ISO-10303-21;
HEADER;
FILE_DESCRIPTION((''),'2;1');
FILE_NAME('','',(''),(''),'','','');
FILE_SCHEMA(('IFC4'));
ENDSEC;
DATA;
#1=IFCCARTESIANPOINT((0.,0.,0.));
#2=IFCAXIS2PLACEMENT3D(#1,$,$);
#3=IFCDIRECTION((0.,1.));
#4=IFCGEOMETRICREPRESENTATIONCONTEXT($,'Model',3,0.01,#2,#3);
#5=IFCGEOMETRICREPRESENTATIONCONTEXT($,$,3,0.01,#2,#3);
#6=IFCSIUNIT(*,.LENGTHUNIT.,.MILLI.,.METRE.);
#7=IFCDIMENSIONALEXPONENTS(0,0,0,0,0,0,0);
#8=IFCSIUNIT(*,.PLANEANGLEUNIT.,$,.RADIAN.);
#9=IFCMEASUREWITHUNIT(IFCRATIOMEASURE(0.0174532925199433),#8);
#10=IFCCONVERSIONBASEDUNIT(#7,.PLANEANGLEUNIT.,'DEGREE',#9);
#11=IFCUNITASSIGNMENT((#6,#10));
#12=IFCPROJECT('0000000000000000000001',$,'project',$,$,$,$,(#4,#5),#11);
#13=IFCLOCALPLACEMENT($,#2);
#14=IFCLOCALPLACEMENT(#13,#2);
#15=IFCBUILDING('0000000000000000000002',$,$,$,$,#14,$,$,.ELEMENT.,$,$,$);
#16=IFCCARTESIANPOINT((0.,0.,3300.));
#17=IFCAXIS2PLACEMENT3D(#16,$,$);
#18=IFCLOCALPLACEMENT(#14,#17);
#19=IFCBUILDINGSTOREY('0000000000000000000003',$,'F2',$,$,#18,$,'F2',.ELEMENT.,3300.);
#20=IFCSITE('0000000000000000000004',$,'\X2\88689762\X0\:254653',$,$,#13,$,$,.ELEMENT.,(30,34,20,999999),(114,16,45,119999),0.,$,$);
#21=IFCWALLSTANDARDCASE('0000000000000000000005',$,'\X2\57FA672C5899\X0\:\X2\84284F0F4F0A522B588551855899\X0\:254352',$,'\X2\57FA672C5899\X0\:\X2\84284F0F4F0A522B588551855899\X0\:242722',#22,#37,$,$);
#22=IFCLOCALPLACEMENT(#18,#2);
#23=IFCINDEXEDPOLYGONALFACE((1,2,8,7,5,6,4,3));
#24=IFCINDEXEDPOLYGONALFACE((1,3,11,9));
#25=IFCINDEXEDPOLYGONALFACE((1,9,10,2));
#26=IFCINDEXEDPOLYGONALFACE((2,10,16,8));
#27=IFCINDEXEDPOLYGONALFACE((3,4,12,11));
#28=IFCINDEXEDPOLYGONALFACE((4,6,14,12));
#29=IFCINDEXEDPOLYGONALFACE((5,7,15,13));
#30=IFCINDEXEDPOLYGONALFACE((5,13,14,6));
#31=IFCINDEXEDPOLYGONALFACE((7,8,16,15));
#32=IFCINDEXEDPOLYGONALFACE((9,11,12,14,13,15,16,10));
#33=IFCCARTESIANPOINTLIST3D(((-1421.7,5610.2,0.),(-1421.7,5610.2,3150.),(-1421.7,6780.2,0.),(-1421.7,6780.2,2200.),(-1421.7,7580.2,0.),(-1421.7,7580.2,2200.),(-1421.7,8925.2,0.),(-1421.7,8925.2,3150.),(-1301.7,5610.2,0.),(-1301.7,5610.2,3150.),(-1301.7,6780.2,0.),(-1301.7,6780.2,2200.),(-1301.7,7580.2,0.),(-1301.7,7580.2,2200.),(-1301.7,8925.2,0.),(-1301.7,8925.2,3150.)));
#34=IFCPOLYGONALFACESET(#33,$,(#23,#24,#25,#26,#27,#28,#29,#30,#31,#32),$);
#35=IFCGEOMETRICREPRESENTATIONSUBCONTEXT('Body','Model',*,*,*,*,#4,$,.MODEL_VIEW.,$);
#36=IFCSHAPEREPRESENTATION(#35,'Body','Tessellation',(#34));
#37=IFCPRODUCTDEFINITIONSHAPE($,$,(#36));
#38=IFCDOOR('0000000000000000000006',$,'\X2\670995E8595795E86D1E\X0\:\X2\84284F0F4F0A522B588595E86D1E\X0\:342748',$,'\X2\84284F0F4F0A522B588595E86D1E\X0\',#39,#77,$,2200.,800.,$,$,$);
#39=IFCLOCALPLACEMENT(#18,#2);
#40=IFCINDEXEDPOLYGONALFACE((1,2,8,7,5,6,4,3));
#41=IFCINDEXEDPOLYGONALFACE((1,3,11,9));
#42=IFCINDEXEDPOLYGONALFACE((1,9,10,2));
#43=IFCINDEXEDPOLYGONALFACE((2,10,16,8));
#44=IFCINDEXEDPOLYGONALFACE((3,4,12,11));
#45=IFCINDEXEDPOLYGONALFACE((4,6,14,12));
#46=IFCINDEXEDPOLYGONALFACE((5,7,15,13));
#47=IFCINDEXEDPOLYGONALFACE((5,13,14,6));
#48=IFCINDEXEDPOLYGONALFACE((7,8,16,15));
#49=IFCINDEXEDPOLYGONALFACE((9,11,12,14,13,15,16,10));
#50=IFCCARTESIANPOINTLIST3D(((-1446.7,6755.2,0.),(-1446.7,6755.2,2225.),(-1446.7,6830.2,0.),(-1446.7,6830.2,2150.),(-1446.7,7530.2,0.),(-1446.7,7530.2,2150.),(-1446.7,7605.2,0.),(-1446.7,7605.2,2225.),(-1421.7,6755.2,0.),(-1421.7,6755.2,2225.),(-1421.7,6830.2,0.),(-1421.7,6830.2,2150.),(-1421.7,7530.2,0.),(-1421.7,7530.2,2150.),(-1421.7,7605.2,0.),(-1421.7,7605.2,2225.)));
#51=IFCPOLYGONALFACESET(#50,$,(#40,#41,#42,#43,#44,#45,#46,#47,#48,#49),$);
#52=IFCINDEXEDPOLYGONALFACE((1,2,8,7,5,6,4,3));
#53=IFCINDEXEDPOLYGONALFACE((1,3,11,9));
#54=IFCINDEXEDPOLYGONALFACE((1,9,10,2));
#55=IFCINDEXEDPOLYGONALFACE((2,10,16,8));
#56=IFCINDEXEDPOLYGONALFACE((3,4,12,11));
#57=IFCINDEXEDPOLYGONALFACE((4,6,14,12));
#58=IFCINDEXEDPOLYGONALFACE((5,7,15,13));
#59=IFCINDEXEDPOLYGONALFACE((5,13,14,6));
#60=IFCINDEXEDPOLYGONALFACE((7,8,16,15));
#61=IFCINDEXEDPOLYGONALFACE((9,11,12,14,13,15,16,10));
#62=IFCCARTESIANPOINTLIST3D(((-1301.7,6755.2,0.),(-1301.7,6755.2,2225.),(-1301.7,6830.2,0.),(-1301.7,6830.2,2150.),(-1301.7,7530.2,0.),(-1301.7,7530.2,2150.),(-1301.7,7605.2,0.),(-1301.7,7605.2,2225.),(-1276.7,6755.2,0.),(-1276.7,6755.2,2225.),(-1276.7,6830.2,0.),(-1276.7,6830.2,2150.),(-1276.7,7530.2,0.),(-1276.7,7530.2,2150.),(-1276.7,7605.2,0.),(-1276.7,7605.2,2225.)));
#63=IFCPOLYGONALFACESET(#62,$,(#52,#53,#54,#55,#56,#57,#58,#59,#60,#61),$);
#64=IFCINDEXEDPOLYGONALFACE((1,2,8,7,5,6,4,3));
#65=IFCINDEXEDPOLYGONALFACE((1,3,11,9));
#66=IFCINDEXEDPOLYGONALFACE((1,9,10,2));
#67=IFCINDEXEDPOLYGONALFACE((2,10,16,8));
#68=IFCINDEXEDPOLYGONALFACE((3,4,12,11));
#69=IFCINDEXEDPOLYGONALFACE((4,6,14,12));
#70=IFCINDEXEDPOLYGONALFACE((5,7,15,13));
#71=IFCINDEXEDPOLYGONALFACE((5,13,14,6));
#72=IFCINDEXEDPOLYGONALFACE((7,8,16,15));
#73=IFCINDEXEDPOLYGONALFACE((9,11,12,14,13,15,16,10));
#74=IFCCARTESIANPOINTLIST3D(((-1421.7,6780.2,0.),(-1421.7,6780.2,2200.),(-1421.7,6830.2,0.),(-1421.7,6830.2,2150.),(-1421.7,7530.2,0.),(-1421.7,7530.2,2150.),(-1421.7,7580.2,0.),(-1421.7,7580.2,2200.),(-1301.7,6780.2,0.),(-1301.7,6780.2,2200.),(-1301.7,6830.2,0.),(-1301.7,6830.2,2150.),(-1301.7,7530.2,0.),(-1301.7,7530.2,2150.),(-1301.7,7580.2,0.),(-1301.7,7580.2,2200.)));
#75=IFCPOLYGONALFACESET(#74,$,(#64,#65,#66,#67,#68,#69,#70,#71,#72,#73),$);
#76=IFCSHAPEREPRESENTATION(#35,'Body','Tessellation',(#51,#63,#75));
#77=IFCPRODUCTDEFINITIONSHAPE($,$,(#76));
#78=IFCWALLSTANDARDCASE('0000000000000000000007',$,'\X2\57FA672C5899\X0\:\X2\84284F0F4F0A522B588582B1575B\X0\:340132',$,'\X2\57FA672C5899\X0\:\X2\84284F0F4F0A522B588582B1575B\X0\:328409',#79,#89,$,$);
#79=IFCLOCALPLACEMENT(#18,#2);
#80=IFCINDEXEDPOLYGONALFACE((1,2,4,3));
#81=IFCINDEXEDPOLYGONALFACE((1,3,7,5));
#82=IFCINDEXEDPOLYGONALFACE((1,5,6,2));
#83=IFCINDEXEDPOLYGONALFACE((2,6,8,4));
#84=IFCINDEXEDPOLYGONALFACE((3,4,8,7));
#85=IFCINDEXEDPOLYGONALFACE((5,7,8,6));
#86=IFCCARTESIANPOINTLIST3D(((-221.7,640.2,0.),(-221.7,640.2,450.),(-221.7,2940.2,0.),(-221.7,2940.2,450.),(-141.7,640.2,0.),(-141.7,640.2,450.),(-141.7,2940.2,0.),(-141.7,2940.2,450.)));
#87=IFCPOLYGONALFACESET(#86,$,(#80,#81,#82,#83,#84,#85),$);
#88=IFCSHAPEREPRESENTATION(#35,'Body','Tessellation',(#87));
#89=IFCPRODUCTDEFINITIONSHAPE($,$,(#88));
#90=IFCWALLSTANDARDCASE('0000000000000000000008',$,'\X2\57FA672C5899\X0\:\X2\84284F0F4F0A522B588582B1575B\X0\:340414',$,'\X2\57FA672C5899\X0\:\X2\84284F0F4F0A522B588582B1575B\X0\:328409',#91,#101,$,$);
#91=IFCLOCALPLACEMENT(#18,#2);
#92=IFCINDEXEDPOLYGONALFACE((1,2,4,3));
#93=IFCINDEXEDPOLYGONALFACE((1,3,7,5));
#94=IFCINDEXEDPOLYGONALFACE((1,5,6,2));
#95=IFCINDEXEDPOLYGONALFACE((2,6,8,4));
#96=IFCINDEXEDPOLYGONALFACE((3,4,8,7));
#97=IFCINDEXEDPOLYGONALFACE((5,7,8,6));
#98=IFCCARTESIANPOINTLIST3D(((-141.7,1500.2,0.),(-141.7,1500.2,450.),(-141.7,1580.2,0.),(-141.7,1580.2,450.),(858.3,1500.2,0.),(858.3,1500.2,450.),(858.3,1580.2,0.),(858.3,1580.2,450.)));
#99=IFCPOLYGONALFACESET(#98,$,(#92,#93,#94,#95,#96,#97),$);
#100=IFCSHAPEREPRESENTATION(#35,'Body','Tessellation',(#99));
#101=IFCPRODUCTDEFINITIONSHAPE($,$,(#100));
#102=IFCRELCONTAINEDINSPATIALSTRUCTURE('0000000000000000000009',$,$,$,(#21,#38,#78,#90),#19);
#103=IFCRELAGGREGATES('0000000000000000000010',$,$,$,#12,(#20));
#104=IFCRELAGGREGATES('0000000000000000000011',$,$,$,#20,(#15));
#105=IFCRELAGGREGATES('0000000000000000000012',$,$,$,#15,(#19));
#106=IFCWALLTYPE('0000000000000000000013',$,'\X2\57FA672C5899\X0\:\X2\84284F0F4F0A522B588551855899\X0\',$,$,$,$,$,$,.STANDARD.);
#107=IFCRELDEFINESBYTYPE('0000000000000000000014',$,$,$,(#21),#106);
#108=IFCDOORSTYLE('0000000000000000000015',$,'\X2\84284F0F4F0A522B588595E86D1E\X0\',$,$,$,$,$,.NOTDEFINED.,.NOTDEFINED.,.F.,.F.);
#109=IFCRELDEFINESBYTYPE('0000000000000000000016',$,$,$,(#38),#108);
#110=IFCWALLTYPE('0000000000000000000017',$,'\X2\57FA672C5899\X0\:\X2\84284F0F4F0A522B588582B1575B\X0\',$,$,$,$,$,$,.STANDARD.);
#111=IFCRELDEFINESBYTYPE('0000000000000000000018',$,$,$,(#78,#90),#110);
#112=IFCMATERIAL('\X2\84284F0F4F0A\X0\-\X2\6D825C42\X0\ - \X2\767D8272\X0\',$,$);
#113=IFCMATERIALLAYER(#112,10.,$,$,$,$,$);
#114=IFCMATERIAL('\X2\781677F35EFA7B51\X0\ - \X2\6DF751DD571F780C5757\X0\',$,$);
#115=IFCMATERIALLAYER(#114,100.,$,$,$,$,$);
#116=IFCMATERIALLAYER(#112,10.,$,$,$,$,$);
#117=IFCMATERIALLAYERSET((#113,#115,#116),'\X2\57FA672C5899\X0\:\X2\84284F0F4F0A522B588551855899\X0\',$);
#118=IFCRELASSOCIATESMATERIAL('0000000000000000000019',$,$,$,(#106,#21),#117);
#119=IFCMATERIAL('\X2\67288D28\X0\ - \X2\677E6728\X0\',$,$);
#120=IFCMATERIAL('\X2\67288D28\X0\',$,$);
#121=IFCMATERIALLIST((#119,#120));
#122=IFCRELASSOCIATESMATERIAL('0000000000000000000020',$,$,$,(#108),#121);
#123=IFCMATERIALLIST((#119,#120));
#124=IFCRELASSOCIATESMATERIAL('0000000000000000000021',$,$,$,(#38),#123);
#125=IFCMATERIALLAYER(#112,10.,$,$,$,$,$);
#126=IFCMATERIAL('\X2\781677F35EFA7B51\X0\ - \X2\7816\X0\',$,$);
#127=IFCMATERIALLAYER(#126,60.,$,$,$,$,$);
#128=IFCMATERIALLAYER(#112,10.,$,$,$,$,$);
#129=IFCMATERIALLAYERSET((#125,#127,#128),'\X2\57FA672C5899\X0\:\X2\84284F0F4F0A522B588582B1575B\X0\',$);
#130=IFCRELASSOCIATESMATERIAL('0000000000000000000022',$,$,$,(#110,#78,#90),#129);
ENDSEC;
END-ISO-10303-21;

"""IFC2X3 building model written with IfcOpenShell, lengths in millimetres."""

from ifc_helpers import new_model, entity, si_unit, converted_unit, direction, frame, frame_2d, origin, place, context, subcontext, project, spatial, polyline, rectangle, outline, extrude, clip, bounded_halfspace, source, transform, mapped, material, material_list, layer, layer_set, layer_usage, type_object, type_shapes, element, fill, save


model = new_model("IFC2X3")

# Units and contexts
model_context = context("Model", 3, precision=0.01, world=origin(), true_north=direction((0.0, 1.0)))
context_of_model = context(None, 3, precision=0.01, world=origin(), true_north=direction((0.0, 1.0)))
body_context = subcontext(model_context, "Body", "Model", "MODEL_VIEW")
ifc_project = project(units=[si_unit("LENGTHUNIT", "METRE", prefix="MILLI"), converted_unit("PLANEANGLEUNIT", "DEGREE", entity("IfcRatioMeasure", 0.0174532925199433), si_unit("PLANEANGLEUNIT", "RADIAN"), dimensions=[0, 0, 0, 0, 0, 0, 0])], contexts=[model_context, context_of_model])

# Site, building, storey
site_placement = place(None, origin())
site = spatial("IfcSite", under=ifc_project, at=site_placement, Name="表面:254653", CompositionType="ELEMENT", RefLatitude=(30, 34, 20, 999999), RefLongitude=(114, 16, 45, 119999), RefElevation=0.0)
building_placement = place(site_placement, origin())
building = spatial("IfcBuilding", under=site, at=building_placement, CompositionType="ELEMENT")
storey_placement = place(building_placement, frame((0.0, 0.0, 3300.0)))
storey = spatial("IfcBuildingStorey", under=building, at=storey_placement, Name="F2", LongName="F2", CompositionType="ELEMENT", Elevation=3300.0)

# Wall, opening, door
ifc_material_1 = material(Name="萨伏伊-涂层 - 白色")
ifc_layer_1 = layer(ifc_material_1, 10.0)
ifc_material_2 = material(Name="砖石建筑 - 混凝土砌块")
ifc_layer_2 = layer(ifc_material_2, 100.0)
ifc_layer_3 = layer(ifc_material_1, 10.0)
ifc_layer_set_1 = layer_set([ifc_layer_1, ifc_layer_2, ifc_layer_3], Name="基本墙:萨伏伊别墅内墙")
ifc_layer_usage_1 = layer_usage(ifc_layer_set_1, "AXIS2", "NEGATIVE", 60.0)
wall_type_1 = type_object("IfcWallType", Name="基本墙:萨伏伊别墅内墙", PredefinedType="STANDARD", material=ifc_layer_set_1)
wall_1_placement = place(storey_placement, frame((-1361.7, 8925.2, 0.0), z_axis=(0.0, 0.0, 1.0), x_axis=(0.0, -1.0, 0.0)))
wall_1 = element("IfcWallStandardCase", 1, at=wall_1_placement, inside=storey, type_object=wall_type_1, material=ifc_layer_usage_1, Name="基本墙:萨伏伊别墅内墙:254352", ObjectType="基本墙:萨伏伊别墅内墙:242722", context=body_context, shape_type="Clipping", body=[
    clip(extrude(rectangle(XDim=3315.0, YDim=120.0, at=frame_2d((1657.5, 0.0), x_axis=(-1.0, 0.0))), origin(), (0.0, 0.0, 1.0), 3150.0), bounded_halfspace(frame((0.0, 60.0, 3150.0), z_axis=(0.0, 0.0, -1.0), x_axis=(1.0, 0.0, 0.0)), True, frame((0.0, 60.0, 3150.0)), polyline([(0.0, 0.0), (0.0, -120.0), (3315.0, -120.0), (3315.0, 0.0), (0.0, 0.0)]))),
])
opening_1_placement = place(wall_1_placement, frame((2145.0, 60.0, 0.0)))
opening_1 = element("IfcOpeningElement", 2, at=opening_1_placement, cuts=wall_1, ObjectType="Opening", context=body_context, shape_type="SweptSolid", body=[
    extrude(rectangle(XDim=2200.0, YDim=800.0, at=frame_2d((1100.0, 400.0), x_axis=(1.0, 0.0))), frame((0.0, 0.0, 0.0), z_axis=(0.0, -1.0, 0.0), x_axis=(0.0, 0.0, 1.0)), (0.0, 0.0, 1.0), 120.0),
])
ifc_material_3 = material(Name="木质 - 松木")
ifc_material_4 = material(Name="木质")
ifc_material_list_1 = material_list([ifc_material_3, ifc_material_4])
ifc_material_list_2 = material_list([ifc_material_3, ifc_material_4])
door_style = type_object("IfcDoorStyle", Name="萨伏伊别墅门洞", ConstructionType="NOTDEFINED", OperationType="NOTDEFINED", ParameterTakesPrecedence=False, Sizeable=False, material=ifc_material_list_2)
shared_shape_1 = source(origin(), body_context, "Body", "SweptSolid", [
    extrude(outline(polyline([(-425.0, -1131.2), (425.0, -1131.2), (425.0, 1093.7), (350.0, 1093.7), (350.0, -1056.2), (-350.0, -1056.2), (-350.0, 1093.7), (-425.0, 1093.7), (-425.0, -1131.2)])), frame((400.0, 120.0, 1093.7), z_axis=(0.0, 1.0, 0.0), x_axis=(1.0, 0.0, 0.0)), (0.0, 0.0, 1.0), 25.0),
    extrude(outline(polyline([(-425.0, -1131.2), (425.0, -1131.2), (425.0, 1093.7), (350.0, 1093.7), (350.0, -1056.2), (-350.0, -1056.2), (-350.0, 1093.7), (-425.0, 1093.7), (-425.0, -1131.2)])), frame((400.0, -25.0, 1093.7), z_axis=(0.0, 1.0, 0.0), x_axis=(1.0, 0.0, 0.0)), (0.0, 0.0, 1.0), 25.0),
    extrude(outline(polyline([(-400.0, -1112.5), (400.0, -1112.5), (400.0, 1087.5), (350.0, 1087.5), (350.0, -1062.5), (-350.0, -1062.5), (-350.0, 1087.5), (-400.0, 1087.5), (-400.0, -1112.5)])), frame((400.0, 0.0, 1087.5), z_axis=(0.0, 1.0, 0.0), x_axis=(1.0, 0.0, 0.0)), (0.0, 0.0, 1.0), 120.0),
])
type_shapes(door_style, [shared_shape_1])
door_placement = place(opening_1_placement, frame((0.0, 0.0, 0.0), z_axis=(0.0, 0.0, 1.0), x_axis=(-1.0, 0.0, 0.0)))
door = element("IfcDoor", 3, at=door_placement, inside=storey, type_object=door_style, material=ifc_material_list_1, Name="有门套门洞:萨伏伊别墅门洞:342748", ObjectType="萨伏伊别墅门洞", OverallHeight=2200.0, OverallWidth=800.0, context=body_context, shape_type="MappedRepresentation", body=[
    mapped(shared_shape_1, transform((0.0, 0.0, 0.0), scale=1.0)),
])
fill(opening_1, door)

# Walls
ifc_layer_4 = layer(ifc_material_1, 10.0)
ifc_material_5 = material(Name="砖石建筑 - 砖")
ifc_layer_5 = layer(ifc_material_5, 60.0)
ifc_layer_6 = layer(ifc_material_1, 10.0)
ifc_layer_set_2 = layer_set([ifc_layer_4, ifc_layer_5, ifc_layer_6], Name="基本墙:萨伏伊别墅花坛")
ifc_layer_usage_2 = layer_usage(ifc_layer_set_2, "AXIS2", "NEGATIVE", 40.0)
wall_type_2 = type_object("IfcWallType", Name="基本墙:萨伏伊别墅花坛", PredefinedType="STANDARD", material=ifc_layer_set_2)
wall_2_placement = place(storey_placement, frame((-181.7, 640.2, 0.0), z_axis=(0.0, 0.0, 1.0), x_axis=(0.0, 1.0, 0.0)))
element("IfcWallStandardCase", 4, at=wall_2_placement, inside=storey, type_object=wall_type_2, material=ifc_layer_usage_2, Name="基本墙:萨伏伊别墅花坛:340132", ObjectType="基本墙:萨伏伊别墅花坛:328409", context=body_context, shape_type="SweptSolid", body=[
    extrude(rectangle(XDim=2300.0, YDim=80.0, at=frame_2d((1150.0, 0.0), x_axis=(-1.0, 0.0))), origin(), (0.0, 0.0, 1.0), 450.0),
])
ifc_layer_usage_3 = layer_usage(ifc_layer_set_2, "AXIS2", "NEGATIVE", 40.0)
wall_3_placement = place(storey_placement, frame((-141.7, 1540.2, 0.0)))
element("IfcWallStandardCase", 5, at=wall_3_placement, inside=storey, type_object=wall_type_2, material=ifc_layer_usage_3, Name="基本墙:萨伏伊别墅花坛:340414", ObjectType="基本墙:萨伏伊别墅花坛:328409", context=body_context, shape_type="SweptSolid", body=[
    extrude(rectangle(XDim=1000.0, YDim=80.0, at=frame_2d((500.0, 0.0), x_axis=(-1.0, 0.0))), origin(), (0.0, 0.0, 1.0), 450.0),
])

save(model, "model.ifc")
